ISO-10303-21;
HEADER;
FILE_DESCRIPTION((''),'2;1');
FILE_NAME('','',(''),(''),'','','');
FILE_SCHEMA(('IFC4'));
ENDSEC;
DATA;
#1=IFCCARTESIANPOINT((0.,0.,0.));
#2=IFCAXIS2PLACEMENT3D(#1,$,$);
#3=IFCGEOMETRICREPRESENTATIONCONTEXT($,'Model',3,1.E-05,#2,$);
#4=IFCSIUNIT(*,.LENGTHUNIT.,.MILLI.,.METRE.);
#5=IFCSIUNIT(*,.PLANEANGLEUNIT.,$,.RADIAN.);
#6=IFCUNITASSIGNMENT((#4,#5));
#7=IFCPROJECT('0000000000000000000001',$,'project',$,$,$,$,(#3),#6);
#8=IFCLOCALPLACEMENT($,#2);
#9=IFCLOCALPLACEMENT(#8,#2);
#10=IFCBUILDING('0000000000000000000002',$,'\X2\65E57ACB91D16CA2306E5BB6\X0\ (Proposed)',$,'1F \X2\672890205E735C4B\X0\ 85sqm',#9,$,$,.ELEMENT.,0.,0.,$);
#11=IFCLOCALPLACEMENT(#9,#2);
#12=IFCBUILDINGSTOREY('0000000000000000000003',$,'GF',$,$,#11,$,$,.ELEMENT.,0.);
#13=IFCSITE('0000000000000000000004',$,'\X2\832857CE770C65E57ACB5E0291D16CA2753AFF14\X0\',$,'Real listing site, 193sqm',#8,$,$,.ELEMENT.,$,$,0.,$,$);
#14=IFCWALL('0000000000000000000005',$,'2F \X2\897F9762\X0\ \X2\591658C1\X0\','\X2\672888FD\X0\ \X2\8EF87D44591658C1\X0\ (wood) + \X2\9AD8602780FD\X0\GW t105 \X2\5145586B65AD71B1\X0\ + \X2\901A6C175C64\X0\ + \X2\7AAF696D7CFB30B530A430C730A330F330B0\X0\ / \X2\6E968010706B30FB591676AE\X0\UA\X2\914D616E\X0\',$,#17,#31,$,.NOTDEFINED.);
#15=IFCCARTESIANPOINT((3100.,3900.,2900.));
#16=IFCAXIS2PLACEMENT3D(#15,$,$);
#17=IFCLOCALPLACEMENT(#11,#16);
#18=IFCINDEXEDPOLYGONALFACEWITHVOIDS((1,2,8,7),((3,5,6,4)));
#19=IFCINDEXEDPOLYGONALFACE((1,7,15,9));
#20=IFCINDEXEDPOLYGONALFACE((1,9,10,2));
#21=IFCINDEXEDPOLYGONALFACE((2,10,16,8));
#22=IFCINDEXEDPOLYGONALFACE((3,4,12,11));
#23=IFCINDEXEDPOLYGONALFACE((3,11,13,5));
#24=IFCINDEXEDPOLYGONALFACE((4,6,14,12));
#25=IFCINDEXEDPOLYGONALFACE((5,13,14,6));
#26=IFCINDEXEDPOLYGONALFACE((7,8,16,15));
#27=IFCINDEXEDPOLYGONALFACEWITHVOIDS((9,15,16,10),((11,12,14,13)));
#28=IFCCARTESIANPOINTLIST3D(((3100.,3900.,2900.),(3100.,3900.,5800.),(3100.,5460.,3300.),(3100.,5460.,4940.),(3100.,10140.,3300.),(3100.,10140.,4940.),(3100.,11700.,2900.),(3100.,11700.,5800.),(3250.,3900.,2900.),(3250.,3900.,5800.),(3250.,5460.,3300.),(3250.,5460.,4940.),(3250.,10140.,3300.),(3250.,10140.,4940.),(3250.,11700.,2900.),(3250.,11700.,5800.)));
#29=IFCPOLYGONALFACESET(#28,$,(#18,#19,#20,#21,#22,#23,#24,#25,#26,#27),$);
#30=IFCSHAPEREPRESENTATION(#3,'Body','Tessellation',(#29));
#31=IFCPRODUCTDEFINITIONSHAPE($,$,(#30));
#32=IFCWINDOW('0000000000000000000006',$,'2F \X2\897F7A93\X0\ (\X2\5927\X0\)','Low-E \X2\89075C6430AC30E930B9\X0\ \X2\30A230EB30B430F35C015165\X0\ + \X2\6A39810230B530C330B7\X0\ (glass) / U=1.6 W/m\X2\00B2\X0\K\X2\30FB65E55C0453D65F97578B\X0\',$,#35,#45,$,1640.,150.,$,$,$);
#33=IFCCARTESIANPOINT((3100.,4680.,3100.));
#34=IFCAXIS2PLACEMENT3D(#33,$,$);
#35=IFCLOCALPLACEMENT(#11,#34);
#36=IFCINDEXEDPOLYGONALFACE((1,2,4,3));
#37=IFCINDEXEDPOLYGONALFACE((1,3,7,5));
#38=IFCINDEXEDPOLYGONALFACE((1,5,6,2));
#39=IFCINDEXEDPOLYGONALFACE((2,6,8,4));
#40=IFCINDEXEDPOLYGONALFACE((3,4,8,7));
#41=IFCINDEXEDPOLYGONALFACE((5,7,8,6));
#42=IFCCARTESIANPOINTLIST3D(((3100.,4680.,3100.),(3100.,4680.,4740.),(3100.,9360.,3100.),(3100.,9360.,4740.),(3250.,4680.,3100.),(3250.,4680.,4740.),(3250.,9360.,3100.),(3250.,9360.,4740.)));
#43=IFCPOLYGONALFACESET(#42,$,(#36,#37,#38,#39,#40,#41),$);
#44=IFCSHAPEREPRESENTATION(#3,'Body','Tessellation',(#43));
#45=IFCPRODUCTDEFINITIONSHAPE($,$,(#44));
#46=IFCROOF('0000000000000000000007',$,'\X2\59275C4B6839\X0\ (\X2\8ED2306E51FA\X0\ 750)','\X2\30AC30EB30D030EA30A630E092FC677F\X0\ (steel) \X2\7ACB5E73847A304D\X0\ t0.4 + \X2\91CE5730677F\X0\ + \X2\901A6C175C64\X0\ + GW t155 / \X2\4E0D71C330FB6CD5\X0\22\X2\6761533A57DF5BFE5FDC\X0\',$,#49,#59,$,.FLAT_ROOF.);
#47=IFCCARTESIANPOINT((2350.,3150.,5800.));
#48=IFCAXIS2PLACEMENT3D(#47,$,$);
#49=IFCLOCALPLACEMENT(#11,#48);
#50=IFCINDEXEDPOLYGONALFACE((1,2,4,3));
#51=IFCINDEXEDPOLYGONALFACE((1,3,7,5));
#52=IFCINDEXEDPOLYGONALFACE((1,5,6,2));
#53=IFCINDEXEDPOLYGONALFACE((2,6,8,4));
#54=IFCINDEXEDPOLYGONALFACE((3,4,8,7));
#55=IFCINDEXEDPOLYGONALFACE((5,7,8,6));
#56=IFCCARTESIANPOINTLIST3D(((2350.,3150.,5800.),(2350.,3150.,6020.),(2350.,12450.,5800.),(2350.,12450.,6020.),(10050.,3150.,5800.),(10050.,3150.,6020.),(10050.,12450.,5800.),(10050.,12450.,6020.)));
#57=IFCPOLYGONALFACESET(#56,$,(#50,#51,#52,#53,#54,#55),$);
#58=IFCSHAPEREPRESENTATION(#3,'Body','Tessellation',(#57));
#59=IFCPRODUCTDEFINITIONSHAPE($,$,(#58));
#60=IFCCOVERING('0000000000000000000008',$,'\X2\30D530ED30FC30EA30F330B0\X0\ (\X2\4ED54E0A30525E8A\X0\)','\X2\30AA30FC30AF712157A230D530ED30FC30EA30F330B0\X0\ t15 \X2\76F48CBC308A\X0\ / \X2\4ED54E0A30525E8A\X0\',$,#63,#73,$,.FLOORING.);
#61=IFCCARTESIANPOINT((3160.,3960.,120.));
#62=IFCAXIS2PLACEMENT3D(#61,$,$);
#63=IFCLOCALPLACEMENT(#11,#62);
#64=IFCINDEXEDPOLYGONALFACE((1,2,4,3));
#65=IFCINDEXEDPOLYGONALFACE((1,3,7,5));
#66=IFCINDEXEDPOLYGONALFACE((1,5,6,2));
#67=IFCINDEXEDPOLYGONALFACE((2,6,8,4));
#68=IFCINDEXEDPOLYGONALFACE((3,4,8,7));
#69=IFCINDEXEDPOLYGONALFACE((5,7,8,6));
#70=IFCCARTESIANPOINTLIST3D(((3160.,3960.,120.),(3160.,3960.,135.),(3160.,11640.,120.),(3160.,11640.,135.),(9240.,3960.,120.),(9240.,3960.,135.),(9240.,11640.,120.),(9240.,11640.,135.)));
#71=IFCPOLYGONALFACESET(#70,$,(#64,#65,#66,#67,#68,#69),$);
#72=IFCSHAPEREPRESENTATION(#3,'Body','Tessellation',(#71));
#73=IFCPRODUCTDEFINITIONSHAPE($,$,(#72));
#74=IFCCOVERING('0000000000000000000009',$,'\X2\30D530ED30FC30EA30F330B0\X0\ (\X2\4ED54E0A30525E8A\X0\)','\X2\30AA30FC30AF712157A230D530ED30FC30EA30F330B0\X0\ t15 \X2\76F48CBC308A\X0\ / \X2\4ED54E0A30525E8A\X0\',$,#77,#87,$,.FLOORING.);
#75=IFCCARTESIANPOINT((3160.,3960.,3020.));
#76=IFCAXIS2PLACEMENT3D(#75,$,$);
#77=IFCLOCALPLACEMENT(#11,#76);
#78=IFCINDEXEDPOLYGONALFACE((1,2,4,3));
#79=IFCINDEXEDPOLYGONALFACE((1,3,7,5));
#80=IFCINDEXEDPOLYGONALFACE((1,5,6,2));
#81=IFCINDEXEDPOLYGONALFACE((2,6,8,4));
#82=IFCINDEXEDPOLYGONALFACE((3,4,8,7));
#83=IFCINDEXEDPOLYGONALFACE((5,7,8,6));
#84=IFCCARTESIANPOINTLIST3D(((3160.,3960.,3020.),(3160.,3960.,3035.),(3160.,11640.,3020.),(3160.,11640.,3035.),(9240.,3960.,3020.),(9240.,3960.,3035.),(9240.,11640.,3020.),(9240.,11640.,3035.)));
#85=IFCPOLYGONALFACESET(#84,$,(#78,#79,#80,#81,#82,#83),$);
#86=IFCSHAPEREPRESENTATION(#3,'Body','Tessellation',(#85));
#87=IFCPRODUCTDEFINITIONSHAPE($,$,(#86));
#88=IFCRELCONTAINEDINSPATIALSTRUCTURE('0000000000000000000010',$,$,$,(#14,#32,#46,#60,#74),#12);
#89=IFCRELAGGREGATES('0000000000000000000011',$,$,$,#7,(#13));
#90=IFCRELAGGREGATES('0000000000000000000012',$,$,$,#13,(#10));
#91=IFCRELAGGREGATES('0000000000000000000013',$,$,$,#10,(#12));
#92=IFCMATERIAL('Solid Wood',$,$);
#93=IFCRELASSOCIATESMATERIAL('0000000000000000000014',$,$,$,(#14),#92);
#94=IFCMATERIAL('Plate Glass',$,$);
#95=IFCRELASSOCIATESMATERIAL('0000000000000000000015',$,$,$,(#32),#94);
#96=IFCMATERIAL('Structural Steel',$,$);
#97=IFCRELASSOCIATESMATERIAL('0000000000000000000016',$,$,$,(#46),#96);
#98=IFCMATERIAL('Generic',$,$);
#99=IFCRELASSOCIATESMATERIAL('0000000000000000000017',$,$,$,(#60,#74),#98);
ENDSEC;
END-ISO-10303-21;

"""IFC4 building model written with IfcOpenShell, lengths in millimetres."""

from ifc_helpers import new_model, si_unit, frame, frame_2d, origin, place, context, project, spatial, rectangle, extrude, material, element, fill, save


model = new_model("IFC4")

# Units and contexts
model_context = context("Model", 3, precision=1e-05, world=origin())
ifc_project = project(units=[si_unit("LENGTHUNIT", "METRE", prefix="MILLI"), si_unit("PLANEANGLEUNIT", "RADIAN")], contexts=[model_context])

# Site, building, storey
site_placement = place(None, origin())
site = spatial("IfcSite", under=ifc_project, at=site_placement, Name="茨城県日立市金沢町４", ObjectType="Real listing site, 193sqm", CompositionType="ELEMENT", RefElevation=0.0)
building_placement = place(site_placement, origin())
building = spatial("IfcBuilding", under=site, at=building_placement, Name="日立金沢の家 (Proposed)", ObjectType="1F 木造平屋 85sqm", CompositionType="ELEMENT", ElevationOfRefHeight=0.0, ElevationOfTerrain=0.0)
storey_placement = place(building_placement, origin())
storey = spatial("IfcBuildingStorey", under=building, at=storey_placement, Name="GF", CompositionType="ELEMENT", Elevation=0.0)

# Shared definitions
ifc_material_1 = material(Name="Solid Wood")
ifc_material_2 = material(Name="Generic")

# Shared definitions
ifc_material_3 = material(Name="Plate Glass")

# Wall, opening, window
wall_1_placement = place(storey_placement, frame((3100.0, 3900.0, 2900.0)))
wall_1 = element("IfcWall", 1, at=wall_1_placement, inside=storey, material=ifc_material_1, Name="2F 西面 外壁", Description="木製 軸組外壁 (wood) + 高性能GW t105 充填断熱 + 通気層 + 窯業系サイディング / 準耐火・外皮UA配慮", PredefinedType="NOTDEFINED", context=model_context, shape_type="SweptSolid", body=[
    extrude(rectangle(XDim=150.0, YDim=7800.0, at=frame_2d((75.0, 3900.0))), frame((3100.0, 3900.0, 2900.0)), (0.0, 0.0, 1.0), 2900.0),
])
opening_1_placement = place(storey_placement, frame((3100.0, 4680.0, 3100.0)))
opening_1 = element("IfcOpeningElement", 2, at=opening_1_placement, cuts=wall_1, PredefinedType="NOTDEFINED", context=model_context, shape_type="SweptSolid", body=[
    extrude(rectangle(XDim=150.0, YDim=4680.0, at=frame_2d((75.0, 2340.0))), frame((3100.0, 4680.0, 3100.0)), (0.0, 0.0, 1.0), 1640.0),
])
window_1_placement = place(storey_placement, frame((3100.0, 4680.0, 3100.0)))
window_1 = element("IfcWindow", 3, at=window_1_placement, inside=storey, material=ifc_material_3, Name="2F 西窓 (大)", Description="Low-E 複層ガラス アルゴン封入 + 樹脂サッシ (glass) / U=1.6 W/m²K・日射取得型", OverallHeight=1640.0, OverallWidth=150.0, context=model_context, shape_type="SweptSolid", body=[
    extrude(rectangle(XDim=150.0, YDim=4680.0, at=frame_2d((75.0, 2340.0))), frame((3100.0, 4680.0, 3100.0)), (0.0, 0.0, 1.0), 1640.0),
])
fill(opening_1, window_1)

# Roof
ifc_material_4 = material(Name="Structural Steel")
roof_placement = place(storey_placement, frame((2350.0, 3150.0, 5800.0)))
element("IfcRoof", 4, at=roof_placement, inside=storey, material=ifc_material_4, Name="大屋根 (軒の出 750)", Description="ガルバリウム鋼板 (steel) 立平葺き t0.4 + 野地板 + 通気層 + GW t155 / 不燃・法22条区域対応", PredefinedType="FLAT_ROOF", context=model_context, shape_type="SweptSolid", body=[
    extrude(rectangle(XDim=7700.0, YDim=9300.0, at=frame_2d((3850.0, 4650.0))), frame((2350.0, 3150.0, 5800.0)), (0.0, 0.0, 1.0), 220.0),
])

# Coverings
covering_1_placement = place(storey_placement, frame((3160.0, 3960.0, 120.0)))
element("IfcCovering", 5, at=covering_1_placement, inside=storey, material=ifc_material_2, Name="フローリング (仕上げ床)", Description="オーク無垢フローリング t15 直貼り / 仕上げ床", PredefinedType="FLOORING", context=model_context, shape_type="SweptSolid", body=[
    extrude(rectangle(XDim=6080.0, YDim=7680.0, at=frame_2d((3040.0, 3840.0))), frame((3160.0, 3960.0, 120.0)), (0.0, 0.0, 1.0), 15.0),
])
covering_2_placement = place(storey_placement, frame((3160.0, 3960.0, 3020.0)))
element("IfcCovering", 6, at=covering_2_placement, inside=storey, material=ifc_material_2, Name="フローリング (仕上げ床)", Description="オーク無垢フローリング t15 直貼り / 仕上げ床", PredefinedType="FLOORING", context=model_context, shape_type="SweptSolid", body=[
    extrude(rectangle(XDim=6080.0, YDim=7680.0, at=frame_2d((3040.0, 3840.0))), frame((3160.0, 3960.0, 3020.0)), (0.0, 0.0, 1.0), 15.0),
])

save(model, "model.ifc")
